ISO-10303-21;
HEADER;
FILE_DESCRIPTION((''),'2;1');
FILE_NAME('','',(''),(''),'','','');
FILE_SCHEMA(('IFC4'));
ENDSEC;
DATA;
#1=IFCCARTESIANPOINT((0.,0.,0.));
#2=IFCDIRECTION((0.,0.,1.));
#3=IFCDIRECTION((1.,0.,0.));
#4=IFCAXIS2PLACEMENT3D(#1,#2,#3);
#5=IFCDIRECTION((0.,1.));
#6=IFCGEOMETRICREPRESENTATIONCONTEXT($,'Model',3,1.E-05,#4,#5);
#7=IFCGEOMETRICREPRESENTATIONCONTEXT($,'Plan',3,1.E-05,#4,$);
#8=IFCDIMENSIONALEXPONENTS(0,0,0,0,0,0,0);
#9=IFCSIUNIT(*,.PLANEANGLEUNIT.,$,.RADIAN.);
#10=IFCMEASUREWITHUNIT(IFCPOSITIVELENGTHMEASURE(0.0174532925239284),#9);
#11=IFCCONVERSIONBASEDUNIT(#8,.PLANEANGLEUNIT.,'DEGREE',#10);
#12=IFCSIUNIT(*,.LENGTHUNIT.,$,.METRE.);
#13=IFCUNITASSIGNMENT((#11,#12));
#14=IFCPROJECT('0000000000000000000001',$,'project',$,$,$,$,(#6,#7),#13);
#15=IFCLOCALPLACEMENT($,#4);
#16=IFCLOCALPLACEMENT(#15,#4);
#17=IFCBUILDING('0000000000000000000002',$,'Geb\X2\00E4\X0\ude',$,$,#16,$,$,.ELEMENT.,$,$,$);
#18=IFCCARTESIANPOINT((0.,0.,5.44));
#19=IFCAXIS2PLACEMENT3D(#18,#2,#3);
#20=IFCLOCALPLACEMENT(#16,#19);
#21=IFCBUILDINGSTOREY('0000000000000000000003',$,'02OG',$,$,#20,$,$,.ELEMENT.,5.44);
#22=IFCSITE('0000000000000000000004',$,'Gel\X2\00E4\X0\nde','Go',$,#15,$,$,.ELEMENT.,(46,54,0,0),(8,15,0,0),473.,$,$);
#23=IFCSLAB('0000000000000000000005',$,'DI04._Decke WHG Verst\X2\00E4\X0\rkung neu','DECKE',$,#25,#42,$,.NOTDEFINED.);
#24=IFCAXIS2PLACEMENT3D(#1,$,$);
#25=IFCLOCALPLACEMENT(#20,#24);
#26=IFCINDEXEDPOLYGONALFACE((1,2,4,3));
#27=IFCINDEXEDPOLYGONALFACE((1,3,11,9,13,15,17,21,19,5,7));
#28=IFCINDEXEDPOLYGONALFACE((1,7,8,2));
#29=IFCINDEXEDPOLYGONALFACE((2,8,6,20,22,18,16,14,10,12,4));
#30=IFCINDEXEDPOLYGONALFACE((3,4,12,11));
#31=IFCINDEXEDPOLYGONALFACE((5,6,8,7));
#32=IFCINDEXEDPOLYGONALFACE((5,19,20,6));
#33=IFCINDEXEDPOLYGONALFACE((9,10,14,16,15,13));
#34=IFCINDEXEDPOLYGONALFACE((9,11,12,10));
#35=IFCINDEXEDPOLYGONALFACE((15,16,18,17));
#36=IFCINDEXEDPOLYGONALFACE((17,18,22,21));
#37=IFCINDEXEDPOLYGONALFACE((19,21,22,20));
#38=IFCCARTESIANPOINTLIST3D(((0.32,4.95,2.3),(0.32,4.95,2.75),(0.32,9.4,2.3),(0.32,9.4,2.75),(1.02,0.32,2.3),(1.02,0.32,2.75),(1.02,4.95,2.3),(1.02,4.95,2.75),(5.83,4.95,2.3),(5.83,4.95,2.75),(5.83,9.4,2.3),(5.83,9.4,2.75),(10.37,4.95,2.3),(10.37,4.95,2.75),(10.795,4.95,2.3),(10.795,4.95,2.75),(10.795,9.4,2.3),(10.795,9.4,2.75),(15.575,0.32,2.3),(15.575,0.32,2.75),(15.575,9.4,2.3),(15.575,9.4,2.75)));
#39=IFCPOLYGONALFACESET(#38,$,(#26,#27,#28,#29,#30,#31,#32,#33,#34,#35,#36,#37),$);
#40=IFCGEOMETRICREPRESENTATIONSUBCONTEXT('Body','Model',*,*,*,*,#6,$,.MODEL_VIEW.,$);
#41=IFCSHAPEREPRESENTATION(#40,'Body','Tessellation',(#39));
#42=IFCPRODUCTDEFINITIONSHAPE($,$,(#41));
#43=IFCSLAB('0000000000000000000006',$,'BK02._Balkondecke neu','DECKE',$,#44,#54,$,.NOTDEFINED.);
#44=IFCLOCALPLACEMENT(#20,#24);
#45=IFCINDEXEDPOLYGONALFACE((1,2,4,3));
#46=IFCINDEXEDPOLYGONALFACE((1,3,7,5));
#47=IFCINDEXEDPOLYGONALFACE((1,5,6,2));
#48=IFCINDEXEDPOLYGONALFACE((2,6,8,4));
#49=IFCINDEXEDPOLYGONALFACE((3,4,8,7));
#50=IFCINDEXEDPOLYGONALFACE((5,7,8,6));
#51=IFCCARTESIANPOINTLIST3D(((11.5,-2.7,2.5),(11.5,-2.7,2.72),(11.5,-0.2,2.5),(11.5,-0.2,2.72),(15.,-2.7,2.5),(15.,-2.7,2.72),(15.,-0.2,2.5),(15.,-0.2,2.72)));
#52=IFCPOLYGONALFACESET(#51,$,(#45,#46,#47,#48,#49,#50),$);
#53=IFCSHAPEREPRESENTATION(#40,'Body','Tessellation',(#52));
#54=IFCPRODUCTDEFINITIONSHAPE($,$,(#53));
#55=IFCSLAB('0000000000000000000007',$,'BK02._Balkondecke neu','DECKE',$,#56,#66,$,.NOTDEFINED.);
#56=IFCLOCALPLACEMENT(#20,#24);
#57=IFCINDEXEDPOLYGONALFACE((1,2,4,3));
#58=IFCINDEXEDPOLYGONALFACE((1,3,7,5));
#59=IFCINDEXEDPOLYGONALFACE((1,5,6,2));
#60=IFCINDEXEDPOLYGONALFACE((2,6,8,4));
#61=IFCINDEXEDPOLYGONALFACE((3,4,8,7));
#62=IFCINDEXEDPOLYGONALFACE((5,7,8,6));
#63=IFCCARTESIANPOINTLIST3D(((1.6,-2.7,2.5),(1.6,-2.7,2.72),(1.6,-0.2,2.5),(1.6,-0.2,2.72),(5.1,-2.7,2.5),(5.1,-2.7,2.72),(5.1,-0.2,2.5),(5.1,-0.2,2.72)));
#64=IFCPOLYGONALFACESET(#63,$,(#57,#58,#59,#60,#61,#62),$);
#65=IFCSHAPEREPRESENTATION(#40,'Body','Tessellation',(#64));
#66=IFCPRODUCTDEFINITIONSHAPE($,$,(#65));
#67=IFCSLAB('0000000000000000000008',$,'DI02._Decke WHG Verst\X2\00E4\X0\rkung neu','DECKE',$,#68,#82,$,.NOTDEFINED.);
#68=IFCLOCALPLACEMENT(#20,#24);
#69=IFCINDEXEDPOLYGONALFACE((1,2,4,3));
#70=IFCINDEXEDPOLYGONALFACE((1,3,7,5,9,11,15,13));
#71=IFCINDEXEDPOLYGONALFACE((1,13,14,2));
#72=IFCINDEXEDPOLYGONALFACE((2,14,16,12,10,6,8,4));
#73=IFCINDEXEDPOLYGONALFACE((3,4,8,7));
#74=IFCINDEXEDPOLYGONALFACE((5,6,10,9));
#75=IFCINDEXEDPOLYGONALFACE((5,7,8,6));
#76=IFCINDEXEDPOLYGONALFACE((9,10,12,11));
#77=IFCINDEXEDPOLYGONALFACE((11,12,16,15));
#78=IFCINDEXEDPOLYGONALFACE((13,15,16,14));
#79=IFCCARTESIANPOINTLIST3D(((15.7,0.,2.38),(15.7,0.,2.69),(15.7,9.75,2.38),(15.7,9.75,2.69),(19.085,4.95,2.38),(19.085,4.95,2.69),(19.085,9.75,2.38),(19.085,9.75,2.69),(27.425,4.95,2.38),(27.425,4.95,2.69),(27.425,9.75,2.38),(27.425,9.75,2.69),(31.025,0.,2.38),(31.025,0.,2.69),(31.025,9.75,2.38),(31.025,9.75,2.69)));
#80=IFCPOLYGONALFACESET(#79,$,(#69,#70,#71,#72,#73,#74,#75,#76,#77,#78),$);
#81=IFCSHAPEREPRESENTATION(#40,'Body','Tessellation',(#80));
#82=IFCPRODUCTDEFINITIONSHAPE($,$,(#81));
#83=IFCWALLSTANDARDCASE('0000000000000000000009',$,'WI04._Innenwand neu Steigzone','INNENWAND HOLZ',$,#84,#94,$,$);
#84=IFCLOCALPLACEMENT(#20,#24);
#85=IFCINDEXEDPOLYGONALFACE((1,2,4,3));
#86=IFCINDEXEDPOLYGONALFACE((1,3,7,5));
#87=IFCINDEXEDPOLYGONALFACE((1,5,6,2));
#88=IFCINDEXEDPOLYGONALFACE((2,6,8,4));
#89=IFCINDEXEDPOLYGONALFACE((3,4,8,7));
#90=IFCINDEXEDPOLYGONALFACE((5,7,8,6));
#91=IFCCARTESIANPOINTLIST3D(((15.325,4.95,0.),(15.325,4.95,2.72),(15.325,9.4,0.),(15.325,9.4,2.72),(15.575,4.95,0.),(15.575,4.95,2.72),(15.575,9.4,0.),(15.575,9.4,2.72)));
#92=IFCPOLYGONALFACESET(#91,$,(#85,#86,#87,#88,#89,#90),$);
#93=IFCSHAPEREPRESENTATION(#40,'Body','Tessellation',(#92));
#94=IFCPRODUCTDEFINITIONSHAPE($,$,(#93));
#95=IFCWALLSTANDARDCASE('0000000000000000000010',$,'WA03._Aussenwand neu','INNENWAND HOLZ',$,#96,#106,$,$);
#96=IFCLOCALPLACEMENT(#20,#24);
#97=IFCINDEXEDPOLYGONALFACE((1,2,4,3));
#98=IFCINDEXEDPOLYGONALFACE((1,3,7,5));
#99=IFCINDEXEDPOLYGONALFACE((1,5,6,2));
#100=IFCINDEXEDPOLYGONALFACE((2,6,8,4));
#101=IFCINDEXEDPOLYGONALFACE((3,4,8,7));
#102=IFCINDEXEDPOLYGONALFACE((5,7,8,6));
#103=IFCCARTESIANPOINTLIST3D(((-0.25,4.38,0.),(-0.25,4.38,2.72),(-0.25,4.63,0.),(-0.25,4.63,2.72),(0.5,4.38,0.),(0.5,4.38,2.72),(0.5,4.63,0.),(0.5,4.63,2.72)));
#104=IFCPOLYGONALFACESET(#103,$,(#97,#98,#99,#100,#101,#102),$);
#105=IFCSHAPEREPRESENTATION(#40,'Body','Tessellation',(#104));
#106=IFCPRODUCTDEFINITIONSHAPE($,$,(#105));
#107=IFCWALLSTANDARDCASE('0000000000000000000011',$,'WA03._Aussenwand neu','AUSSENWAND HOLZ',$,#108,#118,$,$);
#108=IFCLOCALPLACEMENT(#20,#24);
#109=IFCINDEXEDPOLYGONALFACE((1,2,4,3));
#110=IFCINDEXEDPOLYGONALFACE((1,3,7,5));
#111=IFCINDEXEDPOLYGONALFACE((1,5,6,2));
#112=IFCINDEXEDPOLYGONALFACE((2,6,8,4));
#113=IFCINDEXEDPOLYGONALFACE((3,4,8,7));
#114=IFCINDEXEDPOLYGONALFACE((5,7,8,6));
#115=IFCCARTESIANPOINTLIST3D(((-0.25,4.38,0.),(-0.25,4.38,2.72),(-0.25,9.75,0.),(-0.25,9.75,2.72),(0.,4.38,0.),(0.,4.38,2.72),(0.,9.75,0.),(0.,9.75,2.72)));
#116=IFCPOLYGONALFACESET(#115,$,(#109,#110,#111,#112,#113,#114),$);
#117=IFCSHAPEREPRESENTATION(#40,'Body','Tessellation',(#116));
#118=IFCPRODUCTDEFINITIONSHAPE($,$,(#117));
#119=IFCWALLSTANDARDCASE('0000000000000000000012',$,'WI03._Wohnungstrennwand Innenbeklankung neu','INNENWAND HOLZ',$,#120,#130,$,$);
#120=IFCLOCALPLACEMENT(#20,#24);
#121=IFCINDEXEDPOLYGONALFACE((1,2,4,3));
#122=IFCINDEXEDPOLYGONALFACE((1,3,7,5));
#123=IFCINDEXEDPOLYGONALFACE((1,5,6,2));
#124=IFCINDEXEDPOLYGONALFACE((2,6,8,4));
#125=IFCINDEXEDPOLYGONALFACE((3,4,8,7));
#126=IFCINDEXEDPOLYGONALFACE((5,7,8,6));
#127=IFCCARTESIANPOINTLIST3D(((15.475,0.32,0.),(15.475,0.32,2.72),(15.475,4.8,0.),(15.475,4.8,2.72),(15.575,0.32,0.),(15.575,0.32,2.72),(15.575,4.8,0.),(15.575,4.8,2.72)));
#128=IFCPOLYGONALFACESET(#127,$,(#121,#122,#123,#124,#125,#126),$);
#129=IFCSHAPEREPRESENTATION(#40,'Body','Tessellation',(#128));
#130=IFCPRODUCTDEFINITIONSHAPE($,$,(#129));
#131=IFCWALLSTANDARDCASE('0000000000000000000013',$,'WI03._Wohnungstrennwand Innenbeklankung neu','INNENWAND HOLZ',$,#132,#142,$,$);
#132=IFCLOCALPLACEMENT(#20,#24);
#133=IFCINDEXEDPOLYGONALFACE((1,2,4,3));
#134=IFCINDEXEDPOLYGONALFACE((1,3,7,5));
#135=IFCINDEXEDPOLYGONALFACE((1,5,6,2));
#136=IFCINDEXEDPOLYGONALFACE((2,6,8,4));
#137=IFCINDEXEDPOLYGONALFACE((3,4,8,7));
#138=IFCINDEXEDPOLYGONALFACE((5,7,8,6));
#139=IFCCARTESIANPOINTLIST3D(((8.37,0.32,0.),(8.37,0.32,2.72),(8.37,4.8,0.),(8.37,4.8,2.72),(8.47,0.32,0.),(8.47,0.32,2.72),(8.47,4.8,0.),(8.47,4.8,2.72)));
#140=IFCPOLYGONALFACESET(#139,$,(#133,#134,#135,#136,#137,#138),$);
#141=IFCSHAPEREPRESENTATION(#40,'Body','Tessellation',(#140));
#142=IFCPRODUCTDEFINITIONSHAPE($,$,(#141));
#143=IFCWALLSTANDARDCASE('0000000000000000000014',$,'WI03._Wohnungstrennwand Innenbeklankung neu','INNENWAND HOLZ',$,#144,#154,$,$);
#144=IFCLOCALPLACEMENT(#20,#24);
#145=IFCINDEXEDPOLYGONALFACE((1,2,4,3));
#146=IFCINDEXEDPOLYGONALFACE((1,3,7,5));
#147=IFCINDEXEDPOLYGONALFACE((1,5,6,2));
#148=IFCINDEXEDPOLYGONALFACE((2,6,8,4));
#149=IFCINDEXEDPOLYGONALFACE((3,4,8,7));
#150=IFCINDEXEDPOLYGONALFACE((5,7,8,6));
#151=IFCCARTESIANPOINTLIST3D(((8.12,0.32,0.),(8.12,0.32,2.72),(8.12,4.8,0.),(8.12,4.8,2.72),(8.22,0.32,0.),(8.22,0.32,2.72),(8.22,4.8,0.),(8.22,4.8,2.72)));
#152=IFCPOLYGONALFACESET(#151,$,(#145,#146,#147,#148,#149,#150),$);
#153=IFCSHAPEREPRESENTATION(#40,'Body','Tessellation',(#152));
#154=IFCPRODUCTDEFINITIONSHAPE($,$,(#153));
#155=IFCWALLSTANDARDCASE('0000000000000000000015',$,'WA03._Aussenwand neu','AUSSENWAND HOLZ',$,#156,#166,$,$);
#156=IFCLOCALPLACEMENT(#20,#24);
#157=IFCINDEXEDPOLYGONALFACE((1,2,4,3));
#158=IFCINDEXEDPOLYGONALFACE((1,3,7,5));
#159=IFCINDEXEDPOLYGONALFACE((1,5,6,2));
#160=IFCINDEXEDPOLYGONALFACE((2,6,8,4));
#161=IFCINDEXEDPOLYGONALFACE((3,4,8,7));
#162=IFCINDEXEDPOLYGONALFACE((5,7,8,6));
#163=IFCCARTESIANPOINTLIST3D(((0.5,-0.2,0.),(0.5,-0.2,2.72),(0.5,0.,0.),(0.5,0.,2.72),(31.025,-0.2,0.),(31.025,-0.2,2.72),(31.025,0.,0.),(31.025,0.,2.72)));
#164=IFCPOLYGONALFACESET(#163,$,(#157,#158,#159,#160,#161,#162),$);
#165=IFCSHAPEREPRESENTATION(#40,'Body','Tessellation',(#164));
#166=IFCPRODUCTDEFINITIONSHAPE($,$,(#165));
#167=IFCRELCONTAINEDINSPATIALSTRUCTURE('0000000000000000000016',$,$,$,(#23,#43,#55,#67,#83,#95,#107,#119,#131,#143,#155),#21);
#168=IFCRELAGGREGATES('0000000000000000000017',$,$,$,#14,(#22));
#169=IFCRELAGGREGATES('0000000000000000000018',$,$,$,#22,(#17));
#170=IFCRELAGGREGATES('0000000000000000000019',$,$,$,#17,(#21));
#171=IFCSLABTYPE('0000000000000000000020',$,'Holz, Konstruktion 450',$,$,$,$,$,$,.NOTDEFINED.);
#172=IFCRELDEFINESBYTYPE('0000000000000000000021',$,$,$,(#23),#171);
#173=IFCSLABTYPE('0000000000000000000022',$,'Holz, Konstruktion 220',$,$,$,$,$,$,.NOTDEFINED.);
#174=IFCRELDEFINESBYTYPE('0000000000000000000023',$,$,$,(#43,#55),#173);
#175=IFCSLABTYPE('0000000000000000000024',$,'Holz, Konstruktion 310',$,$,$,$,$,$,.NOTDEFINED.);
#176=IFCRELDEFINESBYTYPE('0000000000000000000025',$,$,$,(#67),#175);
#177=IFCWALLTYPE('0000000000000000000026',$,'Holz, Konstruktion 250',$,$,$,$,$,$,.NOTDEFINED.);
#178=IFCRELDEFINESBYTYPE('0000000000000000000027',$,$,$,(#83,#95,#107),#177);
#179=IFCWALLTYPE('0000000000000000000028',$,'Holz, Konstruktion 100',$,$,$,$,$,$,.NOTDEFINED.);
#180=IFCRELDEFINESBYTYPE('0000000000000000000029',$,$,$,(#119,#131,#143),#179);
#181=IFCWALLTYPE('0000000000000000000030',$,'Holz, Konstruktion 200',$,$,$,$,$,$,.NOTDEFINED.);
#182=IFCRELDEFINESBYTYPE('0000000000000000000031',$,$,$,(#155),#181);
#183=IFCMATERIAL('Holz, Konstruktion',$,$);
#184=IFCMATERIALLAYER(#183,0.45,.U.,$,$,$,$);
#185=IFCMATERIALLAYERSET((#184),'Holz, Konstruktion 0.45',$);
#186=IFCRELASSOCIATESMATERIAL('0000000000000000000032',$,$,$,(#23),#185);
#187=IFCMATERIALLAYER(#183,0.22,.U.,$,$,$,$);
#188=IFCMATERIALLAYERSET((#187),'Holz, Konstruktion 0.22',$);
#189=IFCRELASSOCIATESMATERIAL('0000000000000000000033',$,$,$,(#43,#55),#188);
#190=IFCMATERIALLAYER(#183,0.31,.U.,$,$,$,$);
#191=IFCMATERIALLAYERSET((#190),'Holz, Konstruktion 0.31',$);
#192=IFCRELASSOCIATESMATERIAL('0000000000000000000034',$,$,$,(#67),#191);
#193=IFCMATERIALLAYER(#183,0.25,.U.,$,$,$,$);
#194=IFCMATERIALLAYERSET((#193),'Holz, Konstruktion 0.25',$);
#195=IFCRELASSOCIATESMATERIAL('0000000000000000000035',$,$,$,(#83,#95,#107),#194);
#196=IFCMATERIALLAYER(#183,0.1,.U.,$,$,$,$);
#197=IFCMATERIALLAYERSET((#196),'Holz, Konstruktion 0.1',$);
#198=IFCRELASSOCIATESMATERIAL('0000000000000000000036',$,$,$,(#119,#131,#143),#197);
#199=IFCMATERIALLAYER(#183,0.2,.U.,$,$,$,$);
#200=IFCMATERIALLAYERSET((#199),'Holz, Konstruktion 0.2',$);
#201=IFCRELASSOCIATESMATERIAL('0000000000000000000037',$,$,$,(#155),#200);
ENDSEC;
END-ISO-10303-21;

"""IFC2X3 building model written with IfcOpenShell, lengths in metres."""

from ifc_helpers import new_model, entity, si_unit, converted_unit, direction, frame, origin_with_axes, place, context, subcontext, project, spatial, polyline, outline, extrude, material, layer, layer_set, layer_usage, type_object, element, save


model = new_model("IFC2X3")

# Units and contexts
model_context = context("Model", 3, precision=1e-05, world=origin_with_axes(), true_north=direction((0.0, 1.0)))
plan_context = context("Plan", 3, precision=1e-05, world=origin_with_axes())
body_context = subcontext(model_context, "Body", "Model", "MODEL_VIEW")
ifc_project = project(units=[converted_unit("PLANEANGLEUNIT", "DEGREE", entity("IfcPositiveLengthMeasure", 0.0174532925239284), si_unit("PLANEANGLEUNIT", "RADIAN"), dimensions=[0, 0, 0, 0, 0, 0, 0]), si_unit("LENGTHUNIT", "METRE")], contexts=[model_context, plan_context])

# Site, building, storey
site_placement = place(None, origin_with_axes())
site = spatial("IfcSite", under=ifc_project, at=site_placement, Name="Gelände", Description="Go", CompositionType="ELEMENT", RefLatitude=(46, 54, 0, 0), RefLongitude=(8, 15, 0, 0), RefElevation=473.0)
building_placement = place(site_placement, origin_with_axes())
building = spatial("IfcBuilding", under=site, at=building_placement, Name="Gebäude", CompositionType="ELEMENT")
storey_placement = place(building_placement, frame((0.0, 0.0, 5.44), z_axis=(0.0, 0.0, 1.0), x_axis=(1.0, 0.0, 0.0)))
storey = spatial("IfcBuildingStorey", under=building, at=storey_placement, Name="02OG", CompositionType="ELEMENT", Elevation=5.44)

# Slabs
ifc_material_1 = material(Name="Holz, Konstruktion")
ifc_layer_1 = layer(ifc_material_1, 0.45, ventilated="UNKNOWN")
ifc_layer_set_1 = layer_set([ifc_layer_1], Name="Holz, Konstruktion 0.45")
ifc_layer_usage_1 = layer_usage(ifc_layer_set_1, "AXIS3", "NEGATIVE", 0.45)
slab_type_1 = type_object("IfcSlabType", Name="Holz, Konstruktion 450", PredefinedType="NOTDEFINED")
slab_1_placement = place(storey_placement, frame((15.575, 0.32, 2.75), z_axis=(0.0, 0.0, 1.0), x_axis=(1.0, 0.0, 0.0)))
element("IfcSlab", 1, at=slab_1_placement, inside=storey, type_object=slab_type_1, material=ifc_layer_usage_1, Name="DI04._Decke WHG Verstärkung neu", Description="DECKE", PredefinedType="NOTDEFINED", context=body_context, shape_type="SweptSolid", body=[
    extrude(outline(polyline([(0.0, 0.0), (0.0, 9.08), (-4.78, 9.08), (-4.78, 4.63), (-5.205, 4.63), (-9.745, 4.63), (-9.745, 9.08), (-15.255, 9.08), (-15.255, 4.63), (-14.555, 4.63), (-14.555, 0.0), (0.0, 0.0)])), frame((0.0, 0.0, -0.45), z_axis=(0.0, 0.0, 1.0), x_axis=(1.0, 0.0, 0.0)), (0.0, 0.0, 1.0), 0.45),
])
ifc_layer_2 = layer(ifc_material_1, 0.22, ventilated="UNKNOWN")
ifc_layer_set_2 = layer_set([ifc_layer_2], Name="Holz, Konstruktion 0.22")
ifc_layer_usage_2 = layer_usage(ifc_layer_set_2, "AXIS3", "NEGATIVE", 0.22)
slab_type_2 = type_object("IfcSlabType", Name="Holz, Konstruktion 220", PredefinedType="NOTDEFINED")
slab_2_placement = place(storey_placement, frame((11.5, -2.7, 2.72), z_axis=(0.0, 0.0, 1.0), x_axis=(1.0, 0.0, 0.0)))
element("IfcSlab", 2, at=slab_2_placement, inside=storey, type_object=slab_type_2, material=ifc_layer_usage_2, Name="BK02._Balkondecke neu", Description="DECKE", PredefinedType="NOTDEFINED", context=body_context, shape_type="SweptSolid", body=[
    extrude(outline(polyline([(0.0, 0.0), (3.5, 0.0), (3.5, 2.5), (0.0, 2.5), (0.0, 0.0)])), frame((0.0, 0.0, -0.22), z_axis=(0.0, 0.0, 1.0), x_axis=(1.0, 0.0, 0.0)), (0.0, 0.0, 1.0), 0.22),
])
ifc_layer_usage_3 = layer_usage(ifc_layer_set_2, "AXIS3", "NEGATIVE", 0.22)
slab_3_placement = place(storey_placement, frame((1.6, -2.7, 2.72), z_axis=(0.0, 0.0, 1.0), x_axis=(1.0, 0.0, 0.0)))
element("IfcSlab", 3, at=slab_3_placement, inside=storey, type_object=slab_type_2, material=ifc_layer_usage_3, Name="BK02._Balkondecke neu", Description="DECKE", PredefinedType="NOTDEFINED", context=body_context, shape_type="SweptSolid", body=[
    extrude(outline(polyline([(0.0, 0.0), (3.5, 0.0), (3.5, 2.5), (0.0, 2.5), (0.0, 0.0)])), frame((0.0, 0.0, -0.22), z_axis=(0.0, 0.0, 1.0), x_axis=(1.0, 0.0, 0.0)), (0.0, 0.0, 1.0), 0.22),
])
ifc_layer_3 = layer(ifc_material_1, 0.31, ventilated="UNKNOWN")
ifc_layer_set_3 = layer_set([ifc_layer_3], Name="Holz, Konstruktion 0.31")
ifc_layer_usage_4 = layer_usage(ifc_layer_set_3, "AXIS3", "NEGATIVE", 0.31)
slab_type_3 = type_object("IfcSlabType", Name="Holz, Konstruktion 310", PredefinedType="NOTDEFINED")
slab_4_placement = place(storey_placement, frame((15.7, 0.0, 2.69), z_axis=(0.0, 0.0, 1.0), x_axis=(1.0, 0.0, 0.0)))
element("IfcSlab", 4, at=slab_4_placement, inside=storey, type_object=slab_type_3, material=ifc_layer_usage_4, Name="DI02._Decke WHG Verstärkung neu", Description="DECKE", PredefinedType="NOTDEFINED", context=body_context, shape_type="SweptSolid", body=[
    extrude(outline(polyline([(0.0, 0.0), (15.325, 0.0), (15.325, 9.75), (11.725, 9.75), (11.725, 4.95), (3.385, 4.95), (3.385, 9.75), (0.0, 9.75), (0.0, 0.0)])), frame((0.0, 0.0, -0.31), z_axis=(0.0, 0.0, 1.0), x_axis=(1.0, 0.0, 0.0)), (0.0, 0.0, 1.0), 0.31),
])

# Walls
ifc_layer_4 = layer(ifc_material_1, 0.25, ventilated="UNKNOWN")
ifc_layer_set_4 = layer_set([ifc_layer_4], Name="Holz, Konstruktion 0.25")
ifc_layer_usage_5 = layer_usage(ifc_layer_set_4, "AXIS2", "NEGATIVE", 0.0)
wall_type_1 = type_object("IfcWallType", Name="Holz, Konstruktion 250", PredefinedType="NOTDEFINED")
wall_1_placement = place(storey_placement, frame((15.325, 4.95, 0.0), z_axis=(0.0, 0.0, 1.0), x_axis=(0.0, 1.0, 0.0)))
element("IfcWallStandardCase", 5, at=wall_1_placement, inside=storey, type_object=wall_type_1, material=ifc_layer_usage_5, Name="WI04._Innenwand neu Steigzone", Description="INNENWAND HOLZ", context=body_context, shape_type="SweptSolid", body=[
    extrude(outline(polyline([(0.0, -0.25), (4.45, -0.25), (4.45, 0.0), (0.0, 0.0), (0.0, -0.25)])), origin_with_axes(), (0.0, 0.0, 1.0), 2.72),
])
ifc_layer_usage_6 = layer_usage(ifc_layer_set_4, "AXIS2", "POSITIVE", 0.0)
wall_2_placement = place(storey_placement, frame((-0.25, 4.38, 0.0), z_axis=(0.0, 0.0, 1.0), x_axis=(1.0, 0.0, 0.0)))
element("IfcWallStandardCase", 6, at=wall_2_placement, inside=storey, type_object=wall_type_1, material=ifc_layer_usage_6, Name="WA03._Aussenwand neu", Description="INNENWAND HOLZ", context=body_context, shape_type="SweptSolid", body=[
    extrude(outline(polyline([(0.0, 0.0), (0.75, 0.0), (0.75, 0.25), (0.0, 0.25), (0.0, 0.0)])), origin_with_axes(), (0.0, 0.0, 1.0), 2.72),
])
ifc_layer_usage_7 = layer_usage(ifc_layer_set_4, "AXIS2", "NEGATIVE", 0.0)
wall_3_placement = place(storey_placement, frame((-0.25, 4.38, 0.0), z_axis=(0.0, 0.0, 1.0), x_axis=(0.0, 1.0, 0.0)))
element("IfcWallStandardCase", 7, at=wall_3_placement, inside=storey, type_object=wall_type_1, material=ifc_layer_usage_7, Name="WA03._Aussenwand neu", Description="AUSSENWAND HOLZ", context=body_context, shape_type="SweptSolid", body=[
    extrude(outline(polyline([(0.0, -0.25), (5.37, -0.25), (5.37, 0.0), (0.0, 0.0), (0.0, -0.25)])), origin_with_axes(), (0.0, 0.0, 1.0), 2.72),
])
ifc_layer_5 = layer(ifc_material_1, 0.1, ventilated="UNKNOWN")
ifc_layer_set_5 = layer_set([ifc_layer_5], Name="Holz, Konstruktion 0.1")
ifc_layer_usage_8 = layer_usage(ifc_layer_set_5, "AXIS2", "POSITIVE", 0.0)
wall_type_2 = type_object("IfcWallType", Name="Holz, Konstruktion 100", PredefinedType="NOTDEFINED")
wall_4_placement = place(storey_placement, frame((15.575, 0.32, 0.0), z_axis=(0.0, 0.0, 1.0), x_axis=(0.0, 1.0, 0.0)))
element("IfcWallStandardCase", 8, at=wall_4_placement, inside=storey, type_object=wall_type_2, material=ifc_layer_usage_8, Name="WI03._Wohnungstrennwand Innenbeklankung neu", Description="INNENWAND HOLZ", context=body_context, shape_type="SweptSolid", body=[
    extrude(outline(polyline([(0.0, 0.0), (4.48, 0.0), (4.48, 0.1), (0.0, 0.1), (0.0, 0.0)])), origin_with_axes(), (0.0, 0.0, 1.0), 2.72),
])
ifc_layer_usage_9 = layer_usage(ifc_layer_set_5, "AXIS2", "NEGATIVE", 0.0)
wall_5_placement = place(storey_placement, frame((8.37, 0.32, 0.0), z_axis=(0.0, 0.0, 1.0), x_axis=(0.0, 1.0, 0.0)))
element("IfcWallStandardCase", 9, at=wall_5_placement, inside=storey, type_object=wall_type_2, material=ifc_layer_usage_9, Name="WI03._Wohnungstrennwand Innenbeklankung neu", Description="INNENWAND HOLZ", context=body_context, shape_type="SweptSolid", body=[
    extrude(outline(polyline([(0.0, -0.1), (4.48, -0.1), (4.48, 0.0), (0.0, 0.0), (0.0, -0.1)])), origin_with_axes(), (0.0, 0.0, 1.0), 2.72),
])
ifc_layer_usage_10 = layer_usage(ifc_layer_set_5, "AXIS2", "POSITIVE", 0.0)
wall_6_placement = place(storey_placement, frame((8.22, 0.32, 0.0), z_axis=(0.0, 0.0, 1.0), x_axis=(0.0, 1.0, 0.0)))
element("IfcWallStandardCase", 10, at=wall_6_placement, inside=storey, type_object=wall_type_2, material=ifc_layer_usage_10, Name="WI03._Wohnungstrennwand Innenbeklankung neu", Description="INNENWAND HOLZ", context=body_context, shape_type="SweptSolid", body=[
    extrude(outline(polyline([(0.0, 0.0), (4.48, 0.0), (4.48, 0.1), (0.0, 0.1), (0.0, 0.0)])), origin_with_axes(), (0.0, 0.0, 1.0), 2.72),
])
ifc_layer_6 = layer(ifc_material_1, 0.2, ventilated="UNKNOWN")
ifc_layer_set_6 = layer_set([ifc_layer_6], Name="Holz, Konstruktion 0.2")
ifc_layer_usage_11 = layer_usage(ifc_layer_set_6, "AXIS2", "POSITIVE", 0.0)
wall_type_3 = type_object("IfcWallType", Name="Holz, Konstruktion 200", PredefinedType="NOTDEFINED")
wall_7_placement = place(storey_placement, frame((0.5, -0.2, 0.0), z_axis=(0.0, 0.0, 1.0), x_axis=(1.0, 0.0, 0.0)))
element("IfcWallStandardCase", 11, at=wall_7_placement, inside=storey, type_object=wall_type_3, material=ifc_layer_usage_11, Name="WA03._Aussenwand neu", Description="AUSSENWAND HOLZ", context=body_context, shape_type="SweptSolid", body=[
    extrude(outline(polyline([(0.0, 0.0), (30.525, 0.0), (30.525, 0.2), (0.0, 0.2), (0.0, 0.0)])), origin_with_axes(), (0.0, 0.0, 1.0), 2.72),
])

save(model, "model.ifc")
